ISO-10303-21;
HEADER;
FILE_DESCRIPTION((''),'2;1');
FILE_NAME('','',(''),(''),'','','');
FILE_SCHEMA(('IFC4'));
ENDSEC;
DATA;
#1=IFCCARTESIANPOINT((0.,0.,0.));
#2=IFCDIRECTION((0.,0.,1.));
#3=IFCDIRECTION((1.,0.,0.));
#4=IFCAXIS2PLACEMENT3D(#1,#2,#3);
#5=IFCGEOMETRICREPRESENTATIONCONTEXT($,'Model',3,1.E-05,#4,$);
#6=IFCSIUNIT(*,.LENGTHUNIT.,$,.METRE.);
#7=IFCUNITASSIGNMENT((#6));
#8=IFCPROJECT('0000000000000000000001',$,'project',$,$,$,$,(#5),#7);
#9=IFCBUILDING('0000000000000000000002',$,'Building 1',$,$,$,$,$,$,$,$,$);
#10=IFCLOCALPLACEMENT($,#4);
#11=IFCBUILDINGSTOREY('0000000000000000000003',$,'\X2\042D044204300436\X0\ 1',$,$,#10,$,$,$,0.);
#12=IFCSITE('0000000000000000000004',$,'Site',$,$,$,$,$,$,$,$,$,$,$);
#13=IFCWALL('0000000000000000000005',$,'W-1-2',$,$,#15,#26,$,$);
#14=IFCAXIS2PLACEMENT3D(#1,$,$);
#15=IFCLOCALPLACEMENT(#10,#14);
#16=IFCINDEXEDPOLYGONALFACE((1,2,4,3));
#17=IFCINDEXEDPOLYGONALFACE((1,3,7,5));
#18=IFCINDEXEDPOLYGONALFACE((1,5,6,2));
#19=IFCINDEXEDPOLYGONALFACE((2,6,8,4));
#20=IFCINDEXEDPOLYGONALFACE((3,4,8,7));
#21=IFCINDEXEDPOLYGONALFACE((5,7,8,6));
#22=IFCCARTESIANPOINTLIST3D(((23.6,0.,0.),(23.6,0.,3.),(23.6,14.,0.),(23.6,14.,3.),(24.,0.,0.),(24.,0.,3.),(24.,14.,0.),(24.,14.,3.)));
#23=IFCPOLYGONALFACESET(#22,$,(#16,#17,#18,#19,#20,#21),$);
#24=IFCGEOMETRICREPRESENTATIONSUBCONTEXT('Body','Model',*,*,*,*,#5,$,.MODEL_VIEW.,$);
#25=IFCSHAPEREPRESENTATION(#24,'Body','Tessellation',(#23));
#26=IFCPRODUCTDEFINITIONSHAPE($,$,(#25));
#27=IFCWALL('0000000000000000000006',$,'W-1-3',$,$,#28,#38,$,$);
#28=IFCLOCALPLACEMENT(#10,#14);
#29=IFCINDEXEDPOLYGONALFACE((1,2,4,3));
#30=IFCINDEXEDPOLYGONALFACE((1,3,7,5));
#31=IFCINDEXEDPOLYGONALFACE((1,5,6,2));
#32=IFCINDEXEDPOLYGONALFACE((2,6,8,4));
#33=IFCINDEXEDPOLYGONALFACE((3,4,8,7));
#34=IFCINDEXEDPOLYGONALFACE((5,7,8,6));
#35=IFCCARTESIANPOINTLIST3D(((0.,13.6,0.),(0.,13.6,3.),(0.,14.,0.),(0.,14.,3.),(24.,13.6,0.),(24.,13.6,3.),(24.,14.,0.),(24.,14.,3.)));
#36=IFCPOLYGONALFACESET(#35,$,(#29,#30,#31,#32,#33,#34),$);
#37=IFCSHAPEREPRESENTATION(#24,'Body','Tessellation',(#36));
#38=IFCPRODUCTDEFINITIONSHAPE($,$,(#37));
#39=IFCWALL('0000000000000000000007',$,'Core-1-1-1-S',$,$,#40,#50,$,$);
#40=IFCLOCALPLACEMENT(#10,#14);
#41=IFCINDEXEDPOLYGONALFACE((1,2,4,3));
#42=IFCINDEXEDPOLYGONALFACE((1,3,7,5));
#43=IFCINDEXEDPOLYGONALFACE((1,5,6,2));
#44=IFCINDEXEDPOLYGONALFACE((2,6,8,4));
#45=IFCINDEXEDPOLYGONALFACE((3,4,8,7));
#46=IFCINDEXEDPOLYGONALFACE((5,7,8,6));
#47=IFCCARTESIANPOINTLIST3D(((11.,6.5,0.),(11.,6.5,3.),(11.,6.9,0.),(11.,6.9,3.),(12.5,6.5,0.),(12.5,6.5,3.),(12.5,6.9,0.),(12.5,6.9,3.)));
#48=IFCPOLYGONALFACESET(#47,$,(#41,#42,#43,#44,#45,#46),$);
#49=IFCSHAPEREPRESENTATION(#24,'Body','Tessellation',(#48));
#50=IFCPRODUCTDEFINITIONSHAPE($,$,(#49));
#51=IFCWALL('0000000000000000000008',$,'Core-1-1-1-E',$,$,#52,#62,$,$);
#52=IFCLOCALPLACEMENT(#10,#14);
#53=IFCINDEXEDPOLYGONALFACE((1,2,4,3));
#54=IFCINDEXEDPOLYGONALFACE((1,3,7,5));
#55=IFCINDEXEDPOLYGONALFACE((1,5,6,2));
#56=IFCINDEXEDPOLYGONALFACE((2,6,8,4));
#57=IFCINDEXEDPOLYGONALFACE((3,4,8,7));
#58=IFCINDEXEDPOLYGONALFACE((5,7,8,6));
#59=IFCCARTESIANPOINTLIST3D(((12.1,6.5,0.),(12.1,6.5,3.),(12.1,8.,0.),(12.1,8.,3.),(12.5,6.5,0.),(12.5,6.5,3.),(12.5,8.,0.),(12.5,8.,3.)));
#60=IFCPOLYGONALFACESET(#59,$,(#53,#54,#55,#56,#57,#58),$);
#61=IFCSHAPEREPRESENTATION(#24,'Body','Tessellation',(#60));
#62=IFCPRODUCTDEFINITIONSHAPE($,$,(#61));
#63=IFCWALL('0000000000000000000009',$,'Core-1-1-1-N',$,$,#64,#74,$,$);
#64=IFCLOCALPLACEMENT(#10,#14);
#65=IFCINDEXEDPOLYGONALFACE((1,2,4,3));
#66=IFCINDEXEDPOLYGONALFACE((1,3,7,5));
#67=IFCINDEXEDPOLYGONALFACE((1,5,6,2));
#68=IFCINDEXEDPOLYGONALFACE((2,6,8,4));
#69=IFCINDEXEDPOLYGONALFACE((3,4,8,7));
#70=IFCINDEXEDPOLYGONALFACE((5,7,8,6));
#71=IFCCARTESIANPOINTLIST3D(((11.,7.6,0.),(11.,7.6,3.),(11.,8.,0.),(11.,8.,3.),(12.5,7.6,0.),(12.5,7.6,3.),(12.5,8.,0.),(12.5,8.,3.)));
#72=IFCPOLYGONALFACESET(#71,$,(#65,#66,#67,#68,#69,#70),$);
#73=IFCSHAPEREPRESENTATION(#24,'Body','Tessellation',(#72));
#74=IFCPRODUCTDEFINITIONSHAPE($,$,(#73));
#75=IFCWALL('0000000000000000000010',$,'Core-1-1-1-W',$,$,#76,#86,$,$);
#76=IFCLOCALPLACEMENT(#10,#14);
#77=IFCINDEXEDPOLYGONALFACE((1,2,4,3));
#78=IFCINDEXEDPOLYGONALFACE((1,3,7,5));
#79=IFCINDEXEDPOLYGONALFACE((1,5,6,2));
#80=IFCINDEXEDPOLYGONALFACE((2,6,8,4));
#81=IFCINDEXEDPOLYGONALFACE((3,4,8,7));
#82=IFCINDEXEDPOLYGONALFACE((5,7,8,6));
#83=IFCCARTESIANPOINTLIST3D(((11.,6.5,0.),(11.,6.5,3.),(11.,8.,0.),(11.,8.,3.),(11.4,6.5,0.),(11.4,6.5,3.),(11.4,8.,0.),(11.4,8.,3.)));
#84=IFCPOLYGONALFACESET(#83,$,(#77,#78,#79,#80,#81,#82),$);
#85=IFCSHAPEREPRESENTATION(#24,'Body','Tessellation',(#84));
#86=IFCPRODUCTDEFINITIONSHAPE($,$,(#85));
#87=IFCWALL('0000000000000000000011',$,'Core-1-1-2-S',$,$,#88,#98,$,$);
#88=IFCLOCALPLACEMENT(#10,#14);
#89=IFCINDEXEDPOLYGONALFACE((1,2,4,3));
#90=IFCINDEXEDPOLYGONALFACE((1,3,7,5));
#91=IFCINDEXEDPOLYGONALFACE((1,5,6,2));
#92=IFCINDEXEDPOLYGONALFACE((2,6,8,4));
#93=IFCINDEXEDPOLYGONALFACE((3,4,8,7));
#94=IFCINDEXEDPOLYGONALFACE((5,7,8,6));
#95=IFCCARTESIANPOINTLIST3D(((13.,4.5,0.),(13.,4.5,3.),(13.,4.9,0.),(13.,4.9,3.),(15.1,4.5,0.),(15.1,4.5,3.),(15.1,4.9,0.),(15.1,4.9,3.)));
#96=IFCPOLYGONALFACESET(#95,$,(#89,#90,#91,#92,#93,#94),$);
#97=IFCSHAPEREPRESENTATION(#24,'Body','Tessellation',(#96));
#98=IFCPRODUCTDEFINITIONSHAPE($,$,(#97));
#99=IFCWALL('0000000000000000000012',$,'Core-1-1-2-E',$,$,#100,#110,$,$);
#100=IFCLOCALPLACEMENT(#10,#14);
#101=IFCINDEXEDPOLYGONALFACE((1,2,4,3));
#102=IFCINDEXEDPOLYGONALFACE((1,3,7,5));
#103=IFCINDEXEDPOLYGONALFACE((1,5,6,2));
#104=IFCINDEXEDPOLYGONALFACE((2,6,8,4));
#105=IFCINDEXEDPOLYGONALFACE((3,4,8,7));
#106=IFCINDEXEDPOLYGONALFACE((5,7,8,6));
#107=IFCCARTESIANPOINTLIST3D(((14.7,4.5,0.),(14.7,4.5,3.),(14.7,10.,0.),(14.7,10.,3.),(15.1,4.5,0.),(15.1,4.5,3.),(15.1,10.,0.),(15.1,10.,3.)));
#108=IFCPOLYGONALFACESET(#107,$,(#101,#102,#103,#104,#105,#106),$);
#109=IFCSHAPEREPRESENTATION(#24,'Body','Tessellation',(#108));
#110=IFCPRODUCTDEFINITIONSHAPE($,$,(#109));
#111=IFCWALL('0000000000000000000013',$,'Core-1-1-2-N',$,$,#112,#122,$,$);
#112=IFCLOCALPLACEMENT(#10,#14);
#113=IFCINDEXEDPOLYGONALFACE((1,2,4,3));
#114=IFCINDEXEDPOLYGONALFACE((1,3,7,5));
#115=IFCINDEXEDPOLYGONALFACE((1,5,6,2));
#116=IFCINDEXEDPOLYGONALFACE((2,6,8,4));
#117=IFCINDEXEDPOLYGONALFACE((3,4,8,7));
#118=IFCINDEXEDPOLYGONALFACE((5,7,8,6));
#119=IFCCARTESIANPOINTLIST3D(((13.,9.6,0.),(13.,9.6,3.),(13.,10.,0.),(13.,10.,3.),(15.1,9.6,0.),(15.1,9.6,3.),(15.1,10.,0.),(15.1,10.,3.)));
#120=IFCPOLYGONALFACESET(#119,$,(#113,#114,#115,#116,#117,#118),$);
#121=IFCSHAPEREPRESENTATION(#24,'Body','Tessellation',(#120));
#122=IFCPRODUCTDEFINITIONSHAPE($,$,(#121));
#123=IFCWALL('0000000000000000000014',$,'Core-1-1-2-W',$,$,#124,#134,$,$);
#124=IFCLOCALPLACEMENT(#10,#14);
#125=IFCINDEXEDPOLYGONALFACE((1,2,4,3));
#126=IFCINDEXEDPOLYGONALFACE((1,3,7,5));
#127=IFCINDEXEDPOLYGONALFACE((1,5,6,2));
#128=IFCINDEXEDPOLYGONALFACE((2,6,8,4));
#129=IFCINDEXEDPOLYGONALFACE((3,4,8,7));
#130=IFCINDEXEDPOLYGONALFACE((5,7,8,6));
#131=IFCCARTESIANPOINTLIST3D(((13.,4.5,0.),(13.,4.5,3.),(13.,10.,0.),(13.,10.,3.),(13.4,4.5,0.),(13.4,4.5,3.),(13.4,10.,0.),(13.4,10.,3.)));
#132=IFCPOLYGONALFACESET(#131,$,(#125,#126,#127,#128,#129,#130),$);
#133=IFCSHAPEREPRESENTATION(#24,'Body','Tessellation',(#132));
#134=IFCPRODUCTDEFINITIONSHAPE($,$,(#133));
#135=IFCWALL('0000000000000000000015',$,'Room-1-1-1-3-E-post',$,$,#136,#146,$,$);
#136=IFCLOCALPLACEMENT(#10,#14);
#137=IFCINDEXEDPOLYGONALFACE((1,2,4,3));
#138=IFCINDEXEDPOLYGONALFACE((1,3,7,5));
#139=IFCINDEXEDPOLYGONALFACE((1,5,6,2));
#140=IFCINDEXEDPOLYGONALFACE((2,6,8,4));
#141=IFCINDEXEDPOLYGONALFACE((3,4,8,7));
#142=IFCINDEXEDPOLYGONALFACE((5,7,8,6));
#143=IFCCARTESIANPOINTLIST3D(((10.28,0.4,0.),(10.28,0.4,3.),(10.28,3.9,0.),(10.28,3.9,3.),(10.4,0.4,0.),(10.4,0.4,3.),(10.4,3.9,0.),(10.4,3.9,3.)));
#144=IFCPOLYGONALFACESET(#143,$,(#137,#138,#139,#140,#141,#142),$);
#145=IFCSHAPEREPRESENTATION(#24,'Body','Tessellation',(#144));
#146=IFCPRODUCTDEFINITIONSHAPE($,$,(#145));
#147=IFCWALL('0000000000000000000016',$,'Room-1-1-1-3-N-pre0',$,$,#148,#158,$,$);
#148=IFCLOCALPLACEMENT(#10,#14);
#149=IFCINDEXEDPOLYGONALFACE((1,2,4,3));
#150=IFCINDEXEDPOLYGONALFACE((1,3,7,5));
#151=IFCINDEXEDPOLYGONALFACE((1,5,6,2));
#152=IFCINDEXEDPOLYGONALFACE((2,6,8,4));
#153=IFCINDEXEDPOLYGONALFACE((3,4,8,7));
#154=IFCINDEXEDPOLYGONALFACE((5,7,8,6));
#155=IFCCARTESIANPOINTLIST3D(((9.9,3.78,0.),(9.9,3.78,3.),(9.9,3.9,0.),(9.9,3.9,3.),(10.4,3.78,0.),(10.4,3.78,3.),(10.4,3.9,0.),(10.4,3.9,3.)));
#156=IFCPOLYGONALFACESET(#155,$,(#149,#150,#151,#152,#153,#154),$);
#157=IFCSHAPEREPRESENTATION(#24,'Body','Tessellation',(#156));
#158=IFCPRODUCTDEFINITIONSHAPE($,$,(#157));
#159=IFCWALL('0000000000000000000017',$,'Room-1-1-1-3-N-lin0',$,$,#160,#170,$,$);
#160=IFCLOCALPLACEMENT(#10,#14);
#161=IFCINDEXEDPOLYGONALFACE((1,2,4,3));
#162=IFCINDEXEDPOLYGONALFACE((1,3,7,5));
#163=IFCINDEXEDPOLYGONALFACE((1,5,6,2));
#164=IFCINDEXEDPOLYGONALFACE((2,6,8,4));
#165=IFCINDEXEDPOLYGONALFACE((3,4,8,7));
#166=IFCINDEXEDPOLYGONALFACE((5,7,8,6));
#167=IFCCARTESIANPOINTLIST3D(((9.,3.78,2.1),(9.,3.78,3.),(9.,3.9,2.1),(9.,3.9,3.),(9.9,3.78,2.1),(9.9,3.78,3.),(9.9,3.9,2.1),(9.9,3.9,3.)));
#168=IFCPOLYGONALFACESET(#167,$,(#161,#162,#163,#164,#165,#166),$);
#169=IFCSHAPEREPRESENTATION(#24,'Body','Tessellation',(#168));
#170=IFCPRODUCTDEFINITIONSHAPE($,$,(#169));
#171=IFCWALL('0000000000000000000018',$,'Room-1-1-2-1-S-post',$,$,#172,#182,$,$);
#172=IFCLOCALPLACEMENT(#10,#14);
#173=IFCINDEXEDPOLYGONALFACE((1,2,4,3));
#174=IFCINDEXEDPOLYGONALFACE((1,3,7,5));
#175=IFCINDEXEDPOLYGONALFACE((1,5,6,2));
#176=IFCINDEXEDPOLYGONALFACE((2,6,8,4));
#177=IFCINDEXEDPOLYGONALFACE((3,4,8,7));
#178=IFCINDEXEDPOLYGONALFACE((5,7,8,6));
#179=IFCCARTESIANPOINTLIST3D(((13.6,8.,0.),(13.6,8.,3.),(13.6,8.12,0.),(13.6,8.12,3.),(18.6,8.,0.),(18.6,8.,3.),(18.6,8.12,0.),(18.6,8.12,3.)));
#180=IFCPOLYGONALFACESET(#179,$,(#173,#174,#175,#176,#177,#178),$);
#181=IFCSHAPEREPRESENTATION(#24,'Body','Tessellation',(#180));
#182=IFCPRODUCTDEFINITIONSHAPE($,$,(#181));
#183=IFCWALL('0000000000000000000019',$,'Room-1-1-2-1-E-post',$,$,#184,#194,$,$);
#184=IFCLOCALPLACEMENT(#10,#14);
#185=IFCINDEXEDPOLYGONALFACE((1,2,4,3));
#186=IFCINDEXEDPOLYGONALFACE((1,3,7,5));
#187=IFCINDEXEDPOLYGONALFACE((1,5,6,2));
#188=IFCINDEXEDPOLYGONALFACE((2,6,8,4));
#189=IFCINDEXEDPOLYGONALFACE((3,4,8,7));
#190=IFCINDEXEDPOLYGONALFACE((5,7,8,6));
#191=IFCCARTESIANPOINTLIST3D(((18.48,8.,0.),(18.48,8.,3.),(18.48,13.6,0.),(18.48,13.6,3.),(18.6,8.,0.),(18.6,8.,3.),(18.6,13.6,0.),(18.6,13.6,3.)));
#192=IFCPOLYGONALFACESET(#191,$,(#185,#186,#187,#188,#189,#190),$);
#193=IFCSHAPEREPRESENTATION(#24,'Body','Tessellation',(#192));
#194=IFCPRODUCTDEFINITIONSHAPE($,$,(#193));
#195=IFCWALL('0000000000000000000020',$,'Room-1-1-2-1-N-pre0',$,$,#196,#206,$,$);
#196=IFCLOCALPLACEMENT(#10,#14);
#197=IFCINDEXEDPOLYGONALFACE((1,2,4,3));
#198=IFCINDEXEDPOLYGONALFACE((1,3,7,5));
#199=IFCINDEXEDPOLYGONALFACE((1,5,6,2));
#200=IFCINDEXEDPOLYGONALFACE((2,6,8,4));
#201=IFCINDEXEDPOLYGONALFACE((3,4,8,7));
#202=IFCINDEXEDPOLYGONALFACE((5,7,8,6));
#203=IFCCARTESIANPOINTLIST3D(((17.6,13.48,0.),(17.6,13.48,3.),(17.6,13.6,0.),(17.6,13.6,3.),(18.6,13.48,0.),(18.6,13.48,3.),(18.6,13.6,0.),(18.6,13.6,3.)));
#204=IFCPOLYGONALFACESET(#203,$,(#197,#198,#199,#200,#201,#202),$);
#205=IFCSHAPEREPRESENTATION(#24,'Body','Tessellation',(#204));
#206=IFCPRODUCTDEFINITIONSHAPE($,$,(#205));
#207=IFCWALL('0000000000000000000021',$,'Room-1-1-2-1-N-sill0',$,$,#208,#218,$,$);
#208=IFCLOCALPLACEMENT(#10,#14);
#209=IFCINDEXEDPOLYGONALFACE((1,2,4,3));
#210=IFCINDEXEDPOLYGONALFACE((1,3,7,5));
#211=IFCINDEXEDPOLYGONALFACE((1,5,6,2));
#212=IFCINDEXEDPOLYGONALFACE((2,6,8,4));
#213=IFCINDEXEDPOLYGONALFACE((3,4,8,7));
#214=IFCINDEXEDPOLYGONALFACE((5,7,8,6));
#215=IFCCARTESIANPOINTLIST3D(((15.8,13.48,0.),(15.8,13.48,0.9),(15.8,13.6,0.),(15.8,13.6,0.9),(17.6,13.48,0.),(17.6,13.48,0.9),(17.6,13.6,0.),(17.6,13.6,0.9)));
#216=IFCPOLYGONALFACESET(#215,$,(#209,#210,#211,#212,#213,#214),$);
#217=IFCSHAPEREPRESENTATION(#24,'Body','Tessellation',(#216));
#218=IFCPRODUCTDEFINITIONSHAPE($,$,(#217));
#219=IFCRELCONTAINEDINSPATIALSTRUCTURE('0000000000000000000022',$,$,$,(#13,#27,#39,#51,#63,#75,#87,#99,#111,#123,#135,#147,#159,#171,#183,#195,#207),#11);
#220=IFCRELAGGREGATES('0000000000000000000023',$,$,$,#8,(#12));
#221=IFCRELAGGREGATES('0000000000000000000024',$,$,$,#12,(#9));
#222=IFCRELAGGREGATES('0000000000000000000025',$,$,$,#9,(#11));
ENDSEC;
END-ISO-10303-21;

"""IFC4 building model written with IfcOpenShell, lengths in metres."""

from ifc_helpers import new_model, si_unit, frame, origin_with_axes, place, context, subcontext, project, spatial, indexed_curve, outline, extrude, element, save


model = new_model("IFC4")

# Units and contexts
model_context = context("Model", 3, precision=1e-05, world=origin_with_axes())
body_context = subcontext(model_context, "Body", "Model", "MODEL_VIEW")
ifc_project = project(units=[si_unit("LENGTHUNIT", "METRE")], contexts=[model_context])

# Site, building, storey
site = spatial("IfcSite", under=ifc_project, Name="Site")
building = spatial("IfcBuilding", under=site, Name="Building 1")
storey_placement = place(None, origin_with_axes())
storey = spatial("IfcBuildingStorey", under=building, at=storey_placement, Name="Этаж 1", Elevation=0.0)

# Walls
wall_1_placement = place(storey_placement, frame((24.0, 0.0, 0.0), z_axis=(0.0, 0.0, 1.0), x_axis=(0.0, 1.0, 0.0)))
element("IfcWall", 1, at=wall_1_placement, inside=storey, Name="W-1-2", context=body_context, shape_type="SweptSolid", body=[
    extrude(outline(indexed_curve([(0.0, 0.0), (0.0, 0.4), (14.0, 0.4), (14.0, 0.0), (0.0, 0.0)], self_intersect=False)), origin_with_axes(), (0.0, 0.0, 1.0), 3.0),
])
wall_2_placement = place(storey_placement, frame((24.0, 14.0, 0.0), z_axis=(0.0, 0.0, 1.0), x_axis=(-1.0, 0.0, 0.0)))
element("IfcWall", 2, at=wall_2_placement, inside=storey, Name="W-1-3", context=body_context, shape_type="SweptSolid", body=[
    extrude(outline(indexed_curve([(0.0, 0.0), (0.0, 0.4), (24.0, 0.4), (24.0, 0.0), (0.0, 0.0)], self_intersect=False)), origin_with_axes(), (0.0, 0.0, 1.0), 3.0),
])
for number, where, z_axis, x_axis, name in (
    (3, (11.0, 6.5, 0.0), (0.0, 0.0, 1.0), (1.0, 0.0, 0.0), "Core-1-1-1-S"),
    (4, (12.5, 6.5, 0.0), (0.0, 0.0, 1.0), (0.0, 1.0, 0.0), "Core-1-1-1-E"),
    (5, (12.5, 8.0, 0.0), (0.0, 0.0, 1.0), (-1.0, 0.0, 0.0), "Core-1-1-1-N"),
    (6, (11.0, 8.0, 0.0), (0.0, 0.0, 1.0), (0.0, -1.0, 0.0), "Core-1-1-1-W"),
):
    element("IfcWall", number, at=place(storey_placement, frame(where, z_axis=z_axis, x_axis=x_axis)), inside=storey, Name=name, context=body_context, shape_type="SweptSolid", body=[
        extrude(outline(indexed_curve([(0.0, 0.0), (0.0, 0.4), (1.5, 0.4), (1.5, 0.0), (0.0, 0.0)], self_intersect=False)), origin_with_axes(), (0.0, 0.0, 1.0), 3.0),
    ])
wall_3_placement = place(storey_placement, frame((13.0, 4.5, 0.0), z_axis=(0.0, 0.0, 1.0), x_axis=(1.0, 0.0, 0.0)))
element("IfcWall", 7, at=wall_3_placement, inside=storey, Name="Core-1-1-2-S", context=body_context, shape_type="SweptSolid", body=[
    extrude(outline(indexed_curve([(0.0, 0.0), (0.0, 0.4), (2.1, 0.4), (2.1, 0.0), (0.0, 0.0)], self_intersect=False)), origin_with_axes(), (0.0, 0.0, 1.0), 3.0),
])
wall_4_placement = place(storey_placement, frame((15.1, 4.5, 0.0), z_axis=(0.0, 0.0, 1.0), x_axis=(0.0, 1.0, 0.0)))
element("IfcWall", 8, at=wall_4_placement, inside=storey, Name="Core-1-1-2-E", context=body_context, shape_type="SweptSolid", body=[
    extrude(outline(indexed_curve([(0.0, 0.0), (0.0, 0.4), (5.5, 0.4), (5.5, 0.0), (0.0, 0.0)], self_intersect=False)), origin_with_axes(), (0.0, 0.0, 1.0), 3.0),
])
wall_5_placement = place(storey_placement, frame((15.1, 10.0, 0.0), z_axis=(0.0, 0.0, 1.0), x_axis=(-1.0, 0.0, 0.0)))
element("IfcWall", 9, at=wall_5_placement, inside=storey, Name="Core-1-1-2-N", context=body_context, shape_type="SweptSolid", body=[
    extrude(outline(indexed_curve([(0.0, 0.0), (0.0, 0.4), (2.1, 0.4), (2.1, 0.0), (0.0, 0.0)], self_intersect=False)), origin_with_axes(), (0.0, 0.0, 1.0), 3.0),
])
wall_6_placement = place(storey_placement, frame((13.0, 10.0, 0.0), z_axis=(0.0, 0.0, 1.0), x_axis=(0.0, -1.0, 0.0)))
element("IfcWall", 10, at=wall_6_placement, inside=storey, Name="Core-1-1-2-W", context=body_context, shape_type="SweptSolid", body=[
    extrude(outline(indexed_curve([(0.0, 0.0), (0.0, 0.4), (5.5, 0.4), (5.5, 0.0), (0.0, 0.0)], self_intersect=False)), origin_with_axes(), (0.0, 0.0, 1.0), 3.0),
])
wall_7_placement = place(storey_placement, frame((10.4, 0.4, 0.0), z_axis=(0.0, 0.0, 1.0), x_axis=(0.0, 1.0, 0.0)))
element("IfcWall", 11, at=wall_7_placement, inside=storey, Name="Room-1-1-1-3-E-post", context=body_context, shape_type="SweptSolid", body=[
    extrude(outline(indexed_curve([(0.0, 0.0), (0.0, 0.12), (3.5, 0.12), (3.5, 0.0), (0.0, 0.0)], self_intersect=False)), origin_with_axes(), (0.0, 0.0, 1.0), 3.0),
])
wall_8_placement = place(storey_placement, frame((10.4, 3.9, 0.0), z_axis=(0.0, 0.0, 1.0), x_axis=(-1.0, 0.0, 0.0)))
element("IfcWall", 12, at=wall_8_placement, inside=storey, Name="Room-1-1-1-3-N-pre0", context=body_context, shape_type="SweptSolid", body=[
    extrude(outline(indexed_curve([(0.0, 0.0), (0.0, 0.12), (0.5, 0.12), (0.5, 0.0), (0.0, 0.0)], self_intersect=False)), origin_with_axes(), (0.0, 0.0, 1.0), 3.0),
])
wall_9_placement = place(storey_placement, frame((9.9, 3.9, 2.1), z_axis=(0.0, 0.0, 1.0), x_axis=(-1.0, 0.0, 0.0)))
element("IfcWall", 13, at=wall_9_placement, inside=storey, Name="Room-1-1-1-3-N-lin0", context=body_context, shape_type="SweptSolid", body=[
    extrude(outline(indexed_curve([(0.0, 0.0), (0.0, 0.12), (0.9, 0.12), (0.9, 0.0), (0.0, 0.0)], self_intersect=False)), origin_with_axes(), (0.0, 0.0, 1.0), 0.9),
])
wall_10_placement = place(storey_placement, frame((13.6, 8.0, 0.0), z_axis=(0.0, 0.0, 1.0), x_axis=(1.0, 0.0, 0.0)))
element("IfcWall", 14, at=wall_10_placement, inside=storey, Name="Room-1-1-2-1-S-post", context=body_context, shape_type="SweptSolid", body=[
    extrude(outline(indexed_curve([(0.0, 0.0), (0.0, 0.12), (5.0, 0.12), (5.0, 0.0), (0.0, 0.0)], self_intersect=False)), origin_with_axes(), (0.0, 0.0, 1.0), 3.0),
])
wall_11_placement = place(storey_placement, frame((18.6, 8.0, 0.0), z_axis=(0.0, 0.0, 1.0), x_axis=(0.0, 1.0, 0.0)))
element("IfcWall", 15, at=wall_11_placement, inside=storey, Name="Room-1-1-2-1-E-post", context=body_context, shape_type="SweptSolid", body=[
    extrude(outline(indexed_curve([(0.0, 0.0), (0.0, 0.12), (5.6, 0.12), (5.6, 0.0), (0.0, 0.0)], self_intersect=False)), origin_with_axes(), (0.0, 0.0, 1.0), 3.0),
])
wall_12_placement = place(storey_placement, frame((18.6, 13.6, 0.0), z_axis=(0.0, 0.0, 1.0), x_axis=(-1.0, 0.0, 0.0)))
element("IfcWall", 16, at=wall_12_placement, inside=storey, Name="Room-1-1-2-1-N-pre0", context=body_context, shape_type="SweptSolid", body=[
    extrude(outline(indexed_curve([(0.0, 0.0), (0.0, 0.12), (1.0, 0.12), (1.0, 0.0), (0.0, 0.0)], self_intersect=False)), origin_with_axes(), (0.0, 0.0, 1.0), 3.0),
])
wall_13_placement = place(storey_placement, frame((17.6, 13.6, 0.0), z_axis=(0.0, 0.0, 1.0), x_axis=(-1.0, 0.0, 0.0)))
element("IfcWall", 17, at=wall_13_placement, inside=storey, Name="Room-1-1-2-1-N-sill0", context=body_context, shape_type="SweptSolid", body=[
    extrude(outline(indexed_curve([(0.0, 0.0), (0.0, 0.12), (1.8, 0.12), (1.8, 0.0), (0.0, 0.0)], self_intersect=False)), origin_with_axes(), (0.0, 0.0, 1.0), 0.9),
])

save(model, "model.ifc")
